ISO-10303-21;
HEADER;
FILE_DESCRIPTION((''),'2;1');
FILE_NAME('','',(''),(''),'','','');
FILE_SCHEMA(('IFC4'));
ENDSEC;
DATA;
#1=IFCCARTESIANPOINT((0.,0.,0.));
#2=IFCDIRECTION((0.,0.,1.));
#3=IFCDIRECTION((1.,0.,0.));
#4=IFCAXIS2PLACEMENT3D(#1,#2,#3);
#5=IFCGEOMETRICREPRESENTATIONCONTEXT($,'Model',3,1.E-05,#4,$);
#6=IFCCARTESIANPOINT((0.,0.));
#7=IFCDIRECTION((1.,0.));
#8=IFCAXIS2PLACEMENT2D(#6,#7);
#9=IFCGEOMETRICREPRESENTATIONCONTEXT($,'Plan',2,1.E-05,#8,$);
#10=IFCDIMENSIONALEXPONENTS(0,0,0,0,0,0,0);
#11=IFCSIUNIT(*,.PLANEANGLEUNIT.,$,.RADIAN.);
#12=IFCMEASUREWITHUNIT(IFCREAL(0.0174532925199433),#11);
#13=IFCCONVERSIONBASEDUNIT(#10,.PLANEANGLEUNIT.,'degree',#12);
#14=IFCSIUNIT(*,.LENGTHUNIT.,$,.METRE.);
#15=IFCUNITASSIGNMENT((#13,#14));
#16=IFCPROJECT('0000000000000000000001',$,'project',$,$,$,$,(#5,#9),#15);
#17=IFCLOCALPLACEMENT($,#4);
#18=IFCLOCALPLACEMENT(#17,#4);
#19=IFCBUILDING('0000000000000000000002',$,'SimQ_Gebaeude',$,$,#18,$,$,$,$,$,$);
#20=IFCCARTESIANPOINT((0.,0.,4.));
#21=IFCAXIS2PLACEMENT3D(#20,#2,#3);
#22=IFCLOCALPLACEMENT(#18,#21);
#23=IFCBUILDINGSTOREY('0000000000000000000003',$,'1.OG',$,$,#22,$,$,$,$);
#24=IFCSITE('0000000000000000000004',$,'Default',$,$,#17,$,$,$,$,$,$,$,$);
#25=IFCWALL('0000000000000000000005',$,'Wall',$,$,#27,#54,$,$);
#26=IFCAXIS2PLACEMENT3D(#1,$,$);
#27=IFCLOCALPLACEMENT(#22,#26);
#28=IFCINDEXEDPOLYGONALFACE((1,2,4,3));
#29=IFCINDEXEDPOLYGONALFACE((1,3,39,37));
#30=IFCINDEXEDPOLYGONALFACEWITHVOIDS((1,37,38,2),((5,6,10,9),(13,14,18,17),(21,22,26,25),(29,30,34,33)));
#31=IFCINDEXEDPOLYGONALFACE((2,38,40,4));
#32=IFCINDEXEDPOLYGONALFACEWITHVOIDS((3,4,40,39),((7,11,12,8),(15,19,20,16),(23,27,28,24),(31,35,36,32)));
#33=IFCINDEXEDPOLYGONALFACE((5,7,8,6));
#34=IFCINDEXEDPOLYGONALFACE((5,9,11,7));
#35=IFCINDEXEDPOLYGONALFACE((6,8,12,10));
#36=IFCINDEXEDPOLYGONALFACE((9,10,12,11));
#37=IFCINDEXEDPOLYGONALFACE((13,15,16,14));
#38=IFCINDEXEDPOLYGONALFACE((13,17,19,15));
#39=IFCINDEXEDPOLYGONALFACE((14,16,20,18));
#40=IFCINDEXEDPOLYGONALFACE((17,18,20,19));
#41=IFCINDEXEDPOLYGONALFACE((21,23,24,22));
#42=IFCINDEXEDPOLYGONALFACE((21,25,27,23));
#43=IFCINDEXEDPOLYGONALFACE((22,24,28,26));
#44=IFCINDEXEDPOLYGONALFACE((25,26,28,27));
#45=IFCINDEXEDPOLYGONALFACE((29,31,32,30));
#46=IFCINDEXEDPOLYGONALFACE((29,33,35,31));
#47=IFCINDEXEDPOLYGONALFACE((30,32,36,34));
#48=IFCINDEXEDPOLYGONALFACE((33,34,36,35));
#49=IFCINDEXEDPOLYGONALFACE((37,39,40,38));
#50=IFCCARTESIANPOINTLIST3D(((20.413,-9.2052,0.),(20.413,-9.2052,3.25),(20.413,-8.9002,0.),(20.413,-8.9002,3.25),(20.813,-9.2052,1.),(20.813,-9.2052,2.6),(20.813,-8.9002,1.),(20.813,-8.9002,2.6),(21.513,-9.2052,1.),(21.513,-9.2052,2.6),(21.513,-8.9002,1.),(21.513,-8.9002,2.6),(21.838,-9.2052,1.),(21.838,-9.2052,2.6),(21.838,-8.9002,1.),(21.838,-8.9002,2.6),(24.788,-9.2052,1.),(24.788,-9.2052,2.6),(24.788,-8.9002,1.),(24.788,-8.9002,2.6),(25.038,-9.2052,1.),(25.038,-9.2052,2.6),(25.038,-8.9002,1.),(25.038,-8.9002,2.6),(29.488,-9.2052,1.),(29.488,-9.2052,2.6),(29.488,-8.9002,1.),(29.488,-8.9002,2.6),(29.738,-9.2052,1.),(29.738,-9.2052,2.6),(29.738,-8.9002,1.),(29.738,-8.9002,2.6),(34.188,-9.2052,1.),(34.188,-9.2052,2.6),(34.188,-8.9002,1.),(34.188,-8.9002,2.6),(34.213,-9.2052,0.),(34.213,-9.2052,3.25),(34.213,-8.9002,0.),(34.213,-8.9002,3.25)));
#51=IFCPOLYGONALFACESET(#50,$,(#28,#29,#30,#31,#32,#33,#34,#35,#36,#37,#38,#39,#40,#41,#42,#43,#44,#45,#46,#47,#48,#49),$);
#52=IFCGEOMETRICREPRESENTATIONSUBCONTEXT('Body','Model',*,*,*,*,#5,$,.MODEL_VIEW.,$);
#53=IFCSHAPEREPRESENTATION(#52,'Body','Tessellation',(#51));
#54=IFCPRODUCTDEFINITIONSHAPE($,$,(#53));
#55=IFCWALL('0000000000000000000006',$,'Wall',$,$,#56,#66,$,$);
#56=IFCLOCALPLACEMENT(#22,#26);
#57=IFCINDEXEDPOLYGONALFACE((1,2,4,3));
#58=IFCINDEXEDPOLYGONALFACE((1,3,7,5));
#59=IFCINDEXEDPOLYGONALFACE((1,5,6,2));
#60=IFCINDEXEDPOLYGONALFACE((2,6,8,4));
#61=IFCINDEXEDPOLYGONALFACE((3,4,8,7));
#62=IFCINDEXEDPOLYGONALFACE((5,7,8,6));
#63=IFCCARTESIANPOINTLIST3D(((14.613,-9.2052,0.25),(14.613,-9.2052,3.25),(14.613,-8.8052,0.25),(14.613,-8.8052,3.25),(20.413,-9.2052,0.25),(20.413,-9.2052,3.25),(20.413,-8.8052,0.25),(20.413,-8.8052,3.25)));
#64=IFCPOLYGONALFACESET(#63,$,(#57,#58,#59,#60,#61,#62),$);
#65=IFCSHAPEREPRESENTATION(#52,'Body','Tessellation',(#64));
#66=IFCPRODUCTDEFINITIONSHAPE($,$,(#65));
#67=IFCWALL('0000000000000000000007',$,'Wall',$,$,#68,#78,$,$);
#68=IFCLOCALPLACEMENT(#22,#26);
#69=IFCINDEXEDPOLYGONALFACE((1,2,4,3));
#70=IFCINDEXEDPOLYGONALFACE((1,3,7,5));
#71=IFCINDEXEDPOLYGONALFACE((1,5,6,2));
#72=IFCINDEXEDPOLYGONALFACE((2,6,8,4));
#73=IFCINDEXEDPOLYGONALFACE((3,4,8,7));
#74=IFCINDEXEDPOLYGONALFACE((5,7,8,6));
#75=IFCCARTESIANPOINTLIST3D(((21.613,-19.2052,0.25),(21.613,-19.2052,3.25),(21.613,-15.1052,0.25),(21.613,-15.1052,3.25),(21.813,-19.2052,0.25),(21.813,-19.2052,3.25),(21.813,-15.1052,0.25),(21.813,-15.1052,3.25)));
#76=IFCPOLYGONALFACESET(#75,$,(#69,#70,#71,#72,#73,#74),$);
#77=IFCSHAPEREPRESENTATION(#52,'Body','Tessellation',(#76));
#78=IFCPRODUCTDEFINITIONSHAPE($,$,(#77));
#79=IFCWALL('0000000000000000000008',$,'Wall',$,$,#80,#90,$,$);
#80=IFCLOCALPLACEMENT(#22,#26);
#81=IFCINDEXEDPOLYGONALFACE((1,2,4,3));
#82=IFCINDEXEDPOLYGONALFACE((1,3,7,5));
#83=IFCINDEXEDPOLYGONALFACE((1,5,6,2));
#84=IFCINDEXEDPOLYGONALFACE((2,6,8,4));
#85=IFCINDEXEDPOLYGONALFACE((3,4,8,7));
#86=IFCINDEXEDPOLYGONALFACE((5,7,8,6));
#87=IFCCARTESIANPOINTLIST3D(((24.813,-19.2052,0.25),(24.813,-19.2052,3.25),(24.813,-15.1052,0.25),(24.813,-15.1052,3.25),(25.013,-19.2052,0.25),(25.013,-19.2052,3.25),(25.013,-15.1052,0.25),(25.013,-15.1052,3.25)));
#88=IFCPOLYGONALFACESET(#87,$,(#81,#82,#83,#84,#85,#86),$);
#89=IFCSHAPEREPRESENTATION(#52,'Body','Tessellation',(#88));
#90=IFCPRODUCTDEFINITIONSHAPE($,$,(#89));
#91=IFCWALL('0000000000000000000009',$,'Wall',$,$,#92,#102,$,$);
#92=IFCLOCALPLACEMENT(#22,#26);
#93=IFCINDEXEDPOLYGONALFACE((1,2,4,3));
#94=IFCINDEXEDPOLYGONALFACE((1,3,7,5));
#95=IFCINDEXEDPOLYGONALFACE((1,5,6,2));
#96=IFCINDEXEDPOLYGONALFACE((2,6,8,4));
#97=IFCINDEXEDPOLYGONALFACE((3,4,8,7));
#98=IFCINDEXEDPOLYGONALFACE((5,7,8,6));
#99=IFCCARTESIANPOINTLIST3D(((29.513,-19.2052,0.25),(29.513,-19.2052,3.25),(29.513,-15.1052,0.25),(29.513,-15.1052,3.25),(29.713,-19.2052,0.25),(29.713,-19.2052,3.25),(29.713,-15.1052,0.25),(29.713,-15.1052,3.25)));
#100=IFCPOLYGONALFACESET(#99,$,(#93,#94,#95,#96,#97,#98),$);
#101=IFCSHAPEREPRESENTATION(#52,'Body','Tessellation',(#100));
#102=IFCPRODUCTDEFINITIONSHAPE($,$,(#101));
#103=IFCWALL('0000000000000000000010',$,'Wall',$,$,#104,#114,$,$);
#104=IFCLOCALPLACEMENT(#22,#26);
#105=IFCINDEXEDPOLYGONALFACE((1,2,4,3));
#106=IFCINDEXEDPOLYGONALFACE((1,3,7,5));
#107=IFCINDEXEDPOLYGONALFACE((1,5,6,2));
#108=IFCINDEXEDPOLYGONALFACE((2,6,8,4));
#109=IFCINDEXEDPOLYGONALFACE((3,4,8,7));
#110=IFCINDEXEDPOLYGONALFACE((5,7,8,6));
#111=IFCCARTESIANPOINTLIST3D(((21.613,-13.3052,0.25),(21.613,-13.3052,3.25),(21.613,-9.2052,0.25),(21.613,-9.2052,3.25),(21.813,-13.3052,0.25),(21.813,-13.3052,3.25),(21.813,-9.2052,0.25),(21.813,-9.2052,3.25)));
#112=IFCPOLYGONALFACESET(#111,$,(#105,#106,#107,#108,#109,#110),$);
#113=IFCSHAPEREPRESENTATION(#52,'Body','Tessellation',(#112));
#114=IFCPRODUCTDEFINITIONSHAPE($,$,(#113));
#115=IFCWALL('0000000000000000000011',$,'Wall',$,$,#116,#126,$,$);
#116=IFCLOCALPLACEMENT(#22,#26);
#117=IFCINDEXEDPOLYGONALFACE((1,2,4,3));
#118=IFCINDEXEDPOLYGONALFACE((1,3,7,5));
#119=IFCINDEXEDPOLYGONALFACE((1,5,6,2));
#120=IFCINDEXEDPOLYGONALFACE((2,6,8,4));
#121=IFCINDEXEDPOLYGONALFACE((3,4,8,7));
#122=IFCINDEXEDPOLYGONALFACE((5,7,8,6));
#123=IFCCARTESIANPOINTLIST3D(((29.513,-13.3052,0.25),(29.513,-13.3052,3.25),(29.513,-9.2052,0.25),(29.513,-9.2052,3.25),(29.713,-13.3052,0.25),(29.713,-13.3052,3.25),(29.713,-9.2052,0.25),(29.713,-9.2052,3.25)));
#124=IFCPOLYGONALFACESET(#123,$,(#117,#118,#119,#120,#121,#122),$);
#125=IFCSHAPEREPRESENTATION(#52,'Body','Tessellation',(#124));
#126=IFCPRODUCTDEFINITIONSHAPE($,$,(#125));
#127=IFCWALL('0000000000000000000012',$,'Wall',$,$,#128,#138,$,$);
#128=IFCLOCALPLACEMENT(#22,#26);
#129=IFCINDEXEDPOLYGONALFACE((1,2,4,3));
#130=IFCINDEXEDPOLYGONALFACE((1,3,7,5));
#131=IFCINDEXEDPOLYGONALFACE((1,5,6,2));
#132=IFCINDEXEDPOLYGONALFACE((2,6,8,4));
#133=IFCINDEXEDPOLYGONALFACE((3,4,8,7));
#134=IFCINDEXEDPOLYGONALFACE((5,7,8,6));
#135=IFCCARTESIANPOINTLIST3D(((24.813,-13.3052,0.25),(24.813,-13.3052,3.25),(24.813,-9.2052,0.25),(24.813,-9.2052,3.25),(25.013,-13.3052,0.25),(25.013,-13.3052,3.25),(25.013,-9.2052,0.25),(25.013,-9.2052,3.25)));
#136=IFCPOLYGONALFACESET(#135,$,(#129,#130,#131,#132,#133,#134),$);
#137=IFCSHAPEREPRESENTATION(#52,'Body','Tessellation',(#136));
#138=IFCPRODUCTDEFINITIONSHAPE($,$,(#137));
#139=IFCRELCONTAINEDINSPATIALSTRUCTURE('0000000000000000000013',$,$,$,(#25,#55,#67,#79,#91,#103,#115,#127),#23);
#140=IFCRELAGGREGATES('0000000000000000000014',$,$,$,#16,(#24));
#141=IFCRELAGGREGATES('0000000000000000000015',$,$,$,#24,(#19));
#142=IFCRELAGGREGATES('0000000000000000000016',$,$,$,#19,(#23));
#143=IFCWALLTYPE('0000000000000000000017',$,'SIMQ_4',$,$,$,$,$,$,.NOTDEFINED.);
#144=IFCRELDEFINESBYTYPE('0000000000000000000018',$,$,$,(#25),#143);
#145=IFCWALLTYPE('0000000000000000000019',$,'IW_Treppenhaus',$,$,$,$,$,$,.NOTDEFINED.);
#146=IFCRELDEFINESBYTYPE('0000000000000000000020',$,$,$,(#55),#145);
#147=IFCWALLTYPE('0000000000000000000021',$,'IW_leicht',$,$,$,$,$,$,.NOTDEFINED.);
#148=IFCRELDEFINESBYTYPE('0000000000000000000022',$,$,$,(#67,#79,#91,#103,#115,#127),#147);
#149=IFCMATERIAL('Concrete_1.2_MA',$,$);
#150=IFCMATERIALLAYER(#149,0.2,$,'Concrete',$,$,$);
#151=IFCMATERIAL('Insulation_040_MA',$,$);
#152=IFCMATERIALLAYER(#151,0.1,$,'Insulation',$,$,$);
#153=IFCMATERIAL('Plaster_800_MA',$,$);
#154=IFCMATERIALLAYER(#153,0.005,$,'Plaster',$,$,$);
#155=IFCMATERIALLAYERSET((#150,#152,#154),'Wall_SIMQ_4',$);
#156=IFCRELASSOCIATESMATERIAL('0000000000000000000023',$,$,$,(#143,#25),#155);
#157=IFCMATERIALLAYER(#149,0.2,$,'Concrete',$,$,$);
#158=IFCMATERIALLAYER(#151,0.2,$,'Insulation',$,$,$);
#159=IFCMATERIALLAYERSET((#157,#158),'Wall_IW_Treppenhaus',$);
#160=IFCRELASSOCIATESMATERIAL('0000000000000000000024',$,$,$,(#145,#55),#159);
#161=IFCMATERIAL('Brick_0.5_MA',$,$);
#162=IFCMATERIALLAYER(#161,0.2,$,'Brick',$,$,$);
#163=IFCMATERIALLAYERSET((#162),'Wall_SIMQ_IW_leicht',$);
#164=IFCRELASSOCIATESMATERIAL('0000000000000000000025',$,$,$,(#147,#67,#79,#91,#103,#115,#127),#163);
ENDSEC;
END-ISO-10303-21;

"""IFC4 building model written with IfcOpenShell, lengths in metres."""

from ifc_helpers import new_model, entity, si_unit, converted_unit, frame, origin_with_axes, origin_2d_with_axis, place, context, subcontext, project, spatial, line, indexed_curve, outline, extrude, source, transform, mapped, material, layer, layer_set, layer_usage, type_object, element, save


model = new_model("IFC4")

# Units and contexts
model_context = context("Model", 3, precision=1e-05, world=origin_with_axes())
plan_context = context("Plan", 2, precision=1e-05, world=origin_2d_with_axis())
body_context = subcontext(model_context, "Body", "Model", "MODEL_VIEW")
ifc_project = project(units=[converted_unit("PLANEANGLEUNIT", "degree", entity("IfcReal", 0.0174532925199433), si_unit("PLANEANGLEUNIT", "RADIAN"), dimensions=[0, 0, 0, 0, 0, 0, 0]), si_unit("LENGTHUNIT", "METRE")], contexts=[model_context, plan_context])

# Site, building, storey
site_placement = place(None, origin_with_axes())
site = spatial("IfcSite", under=ifc_project, at=site_placement, Name="Default")
building_placement = place(site_placement, origin_with_axes())
building = spatial("IfcBuilding", under=site, at=building_placement, Name="SimQ_Gebaeude")
storey_placement = place(building_placement, frame((0.0, 0.0, 4.0), z_axis=(0.0, 0.0, 1.0), x_axis=(1.0, 0.0, 0.0)))
storey = spatial("IfcBuildingStorey", under=building, at=storey_placement, Name="1.OG")

# Shared definitions
ifc_material_1 = material(Name="Concrete_1.2_MA")

# Wall, openings
ifc_layer_1 = layer(ifc_material_1, 0.2, Name="Concrete")
ifc_material_2 = material(Name="Insulation_040_MA")
ifc_layer_2 = layer(ifc_material_2, 0.1, Name="Insulation")
ifc_material_3 = material(Name="Plaster_800_MA")
ifc_layer_3 = layer(ifc_material_3, 0.005, Name="Plaster")
ifc_layer_set_1 = layer_set([ifc_layer_1, ifc_layer_2, ifc_layer_3], Name="Wall_SIMQ_4")
wall_type_1 = type_object("IfcWallType", Name="SIMQ_4", PredefinedType="NOTDEFINED", material=ifc_layer_set_1)
shared_shape_1 = source(origin_with_axes(), body_context, "Body", "SweptSolid", [
    extrude(outline(indexed_curve([(0.0, 0.0), (4.45, 0.0), (4.45, 1.6), (0.0, 1.6)], segments=[line(1, 2, 3, 4, 1)])), frame((0.0, -0.6, 0.0), z_axis=(0.0, -1.0, 0.0), x_axis=(1.0, 0.0, 0.0)), (0.0, 0.0, -1.0), 1.2),
])
shared_shape_2 = source(origin_with_axes(), body_context, "Body", "SweptSolid", [
    extrude(outline(indexed_curve([(0.0, 0.0), (2.95, 0.0), (2.95, 1.6), (0.0, 1.6)], segments=[line(1, 2, 3, 4, 1)])), frame((0.0, -0.6, 0.0), z_axis=(0.0, -1.0, 0.0), x_axis=(1.0, 0.0, 0.0)), (0.0, 0.0, -1.0), 1.2),
])
ifc_layer_usage_1 = layer_usage(ifc_layer_set_1, "AXIS2", "POSITIVE", 0.0)
wall_1_placement = place(storey_placement, frame((34.213, -8.9002, 0.0), z_axis=(0.0, 0.0, 1.0), x_axis=(-1.0, 0.0, 0.0)))
wall_1 = element("IfcWall", 1, at=wall_1_placement, inside=storey, type_object=wall_type_1, material=ifc_layer_usage_1, Name="Wall", context=body_context, shape_type="SweptSolid", body=[
    extrude(outline(indexed_curve([(0.0, 0.0), (0.0, 0.305), (13.8, 0.305), (13.8, 0.0), (0.0, 0.0)], self_intersect=False)), origin_with_axes(), (0.0, 0.0, 1.0), 3.25),
])
shared_shape_3 = source(origin_with_axes(), body_context, "Body", "SweptSolid", [
    extrude(outline(indexed_curve([(0.0, 0.0), (0.7, 0.0), (0.7, 1.6), (0.0, 1.6)], segments=[line(1, 2, 3, 4, 1)])), frame((0.0, -0.6, 0.0), z_axis=(0.0, -1.0, 0.0), x_axis=(1.0, 0.0, 0.0)), (0.0, 0.0, -1.0), 1.2),
])
opening_1_placement = place(wall_1_placement, frame((12.7, 0.0, 1.0), z_axis=(0.0, 0.0, 1.0), x_axis=(1.0, 0.0, 0.0)))
element("IfcOpeningElement", 2, at=opening_1_placement, cuts=wall_1, PredefinedType="OPENING", context=body_context, shape_type="MappedRepresentation", body=[
    mapped(shared_shape_3, transform((0.0, 0.0, 0.0), x_axis=(1.0, 0.0, 0.0), y_axis=(0.0, 1.0, 0.0), z_axis=(0.0, 0.0, 1.0), scale=1.0)),
])
opening_2_placement = place(wall_1_placement, frame((0.025, 0.0, 1.0), z_axis=(0.0, 0.0, 1.0), x_axis=(1.0, 0.0, 0.0)))
element("IfcOpeningElement", 3, at=opening_2_placement, cuts=wall_1, PredefinedType="OPENING", context=body_context, shape_type="MappedRepresentation", body=[
    mapped(shared_shape_1, transform((0.0, 0.0, 0.0), x_axis=(1.0, 0.0, 0.0), y_axis=(0.0, 1.0, 0.0), z_axis=(0.0, 0.0, 1.0), scale=1.0)),
])
opening_3_placement = place(wall_1_placement, frame((4.725, 0.0, 1.0), z_axis=(0.0, 0.0, 1.0), x_axis=(1.0, 0.0, 0.0)))
element("IfcOpeningElement", 4, at=opening_3_placement, cuts=wall_1, PredefinedType="OPENING", context=body_context, shape_type="MappedRepresentation", body=[
    mapped(shared_shape_1, transform((0.0, 0.0, 0.0), x_axis=(1.0, 0.0, 0.0), y_axis=(0.0, 1.0, 0.0), z_axis=(0.0, 0.0, 1.0), scale=1.0)),
])
opening_4_placement = place(wall_1_placement, frame((9.425, 0.0, 1.0), z_axis=(0.0, 0.0, 1.0), x_axis=(1.0, 0.0, 0.0)))
element("IfcOpeningElement", 5, at=opening_4_placement, cuts=wall_1, PredefinedType="OPENING", context=body_context, shape_type="MappedRepresentation", body=[
    mapped(shared_shape_2, transform((0.0, 0.0, 0.0), x_axis=(1.0, 0.0, 0.0), y_axis=(0.0, 1.0, 0.0), z_axis=(0.0, 0.0, 1.0), scale=1.0)),
])

# Walls
ifc_layer_4 = layer(ifc_material_1, 0.2, Name="Concrete")
ifc_layer_5 = layer(ifc_material_2, 0.2, Name="Insulation")
ifc_layer_set_2 = layer_set([ifc_layer_4, ifc_layer_5], Name="Wall_IW_Treppenhaus")
ifc_layer_usage_2 = layer_usage(ifc_layer_set_2, "AXIS2", "POSITIVE", 0.0)
wall_type_2 = type_object("IfcWallType", Name="IW_Treppenhaus", PredefinedType="NOTDEFINED", material=ifc_layer_set_2)
wall_2_placement = place(storey_placement, frame((20.413, -8.8052, 0.25), z_axis=(0.0, 0.0, 1.0), x_axis=(-1.0, 0.000001, 0.0)))
element("IfcWall", 6, at=wall_2_placement, inside=storey, type_object=wall_type_2, material=ifc_layer_usage_2, Name="Wall", context=body_context, shape_type="SweptSolid", body=[
    extrude(outline(indexed_curve([(0.0, 0.0), (0.0, 0.4), (5.8, 0.4), (5.8, 0.0), (0.0, 0.0)], self_intersect=False)), origin_with_axes(), (0.0, 0.0, 1.0), 3.0),
])
ifc_material_4 = material(Name="Brick_0.5_MA")
ifc_layer_6 = layer(ifc_material_4, 0.2, Name="Brick")
ifc_layer_set_3 = layer_set([ifc_layer_6], Name="Wall_SIMQ_IW_leicht")
ifc_layer_usage_3 = layer_usage(ifc_layer_set_3, "AXIS2", "POSITIVE", 0.0)
wall_type_3 = type_object("IfcWallType", Name="IW_leicht", PredefinedType="NOTDEFINED", material=ifc_layer_set_3)
wall_3_placement = place(storey_placement, frame((21.813, -19.2052, 0.25), z_axis=(0.0, 0.0, 1.0), x_axis=(0.0, 1.0, 0.0)))
element("IfcWall", 7, at=wall_3_placement, inside=storey, type_object=wall_type_3, material=ifc_layer_usage_3, Name="Wall", context=body_context, shape_type="SweptSolid", body=[
    extrude(outline(indexed_curve([(0.0, 0.0), (0.0, 0.2), (4.1, 0.2), (4.1, 0.0), (0.0, 0.0)], self_intersect=False)), origin_with_axes(), (0.0, 0.0, 1.0), 3.0),
])
ifc_layer_usage_4 = layer_usage(ifc_layer_set_3, "AXIS2", "POSITIVE", 0.0)
wall_4_placement = place(storey_placement, frame((25.013, -19.2052, 0.25), z_axis=(0.0, 0.0, 1.0), x_axis=(0.0, 1.0, 0.0)))
element("IfcWall", 8, at=wall_4_placement, inside=storey, type_object=wall_type_3, material=ifc_layer_usage_4, Name="Wall", context=body_context, shape_type="SweptSolid", body=[
    extrude(outline(indexed_curve([(0.0, 0.0), (0.0, 0.2), (4.1, 0.2), (4.1, 0.0), (0.0, 0.0)], self_intersect=False)), origin_with_axes(), (0.0, 0.0, 1.0), 3.0),
])
ifc_layer_usage_5 = layer_usage(ifc_layer_set_3, "AXIS2", "POSITIVE", 0.0)
wall_5_placement = place(storey_placement, frame((29.713, -19.2052, 0.25), z_axis=(0.0, 0.0, 1.0), x_axis=(0.0, 1.0, 0.0)))
element("IfcWall", 9, at=wall_5_placement, inside=storey, type_object=wall_type_3, material=ifc_layer_usage_5, Name="Wall", context=body_context, shape_type="SweptSolid", body=[
    extrude(outline(indexed_curve([(0.0, 0.0), (0.0, 0.2), (4.1, 0.2), (4.1, 0.0), (0.0, 0.0)], self_intersect=False)), origin_with_axes(), (0.0, 0.0, 1.0), 3.0),
])
ifc_layer_usage_6 = layer_usage(ifc_layer_set_3, "AXIS2", "POSITIVE", 0.0)
wall_6_placement = place(storey_placement, frame((21.813, -13.3052, 0.25), z_axis=(0.0, 0.0, 1.0), x_axis=(0.0, 1.0, 0.0)))
element("IfcWall", 10, at=wall_6_placement, inside=storey, type_object=wall_type_3, material=ifc_layer_usage_6, Name="Wall", context=body_context, shape_type="SweptSolid", body=[
    extrude(outline(indexed_curve([(0.0, 0.0), (0.0, 0.2), (4.1, 0.2), (4.1, 0.0), (0.0, 0.0)], self_intersect=False)), origin_with_axes(), (0.0, 0.0, 1.0), 3.0),
])
ifc_layer_usage_7 = layer_usage(ifc_layer_set_3, "AXIS2", "POSITIVE", 0.0)
wall_7_placement = place(storey_placement, frame((29.713, -13.3052, 0.25), z_axis=(0.0, 0.0, 1.0), x_axis=(0.0, 1.0, 0.0)))
element("IfcWall", 11, at=wall_7_placement, inside=storey, type_object=wall_type_3, material=ifc_layer_usage_7, Name="Wall", context=body_context, shape_type="SweptSolid", body=[
    extrude(outline(indexed_curve([(0.0, 0.0), (0.0, 0.2), (4.1, 0.2), (4.1, 0.0), (0.0, 0.0)], self_intersect=False)), origin_with_axes(), (0.0, 0.0, 1.0), 3.0),
])
ifc_layer_usage_8 = layer_usage(ifc_layer_set_3, "AXIS2", "POSITIVE", 0.0)
wall_8_placement = place(storey_placement, frame((25.013, -13.3052, 0.25), z_axis=(0.0, 0.0, 1.0), x_axis=(0.0, 1.0, 0.0)))
element("IfcWall", 12, at=wall_8_placement, inside=storey, type_object=wall_type_3, material=ifc_layer_usage_8, Name="Wall", context=body_context, shape_type="SweptSolid", body=[
    extrude(outline(indexed_curve([(0.0, 0.0), (0.0, 0.2), (4.1, 0.2), (4.1, 0.0), (0.0, 0.0)], self_intersect=False)), origin_with_axes(), (0.0, 0.0, 1.0), 3.0),
])

save(model, "model.ifc")
